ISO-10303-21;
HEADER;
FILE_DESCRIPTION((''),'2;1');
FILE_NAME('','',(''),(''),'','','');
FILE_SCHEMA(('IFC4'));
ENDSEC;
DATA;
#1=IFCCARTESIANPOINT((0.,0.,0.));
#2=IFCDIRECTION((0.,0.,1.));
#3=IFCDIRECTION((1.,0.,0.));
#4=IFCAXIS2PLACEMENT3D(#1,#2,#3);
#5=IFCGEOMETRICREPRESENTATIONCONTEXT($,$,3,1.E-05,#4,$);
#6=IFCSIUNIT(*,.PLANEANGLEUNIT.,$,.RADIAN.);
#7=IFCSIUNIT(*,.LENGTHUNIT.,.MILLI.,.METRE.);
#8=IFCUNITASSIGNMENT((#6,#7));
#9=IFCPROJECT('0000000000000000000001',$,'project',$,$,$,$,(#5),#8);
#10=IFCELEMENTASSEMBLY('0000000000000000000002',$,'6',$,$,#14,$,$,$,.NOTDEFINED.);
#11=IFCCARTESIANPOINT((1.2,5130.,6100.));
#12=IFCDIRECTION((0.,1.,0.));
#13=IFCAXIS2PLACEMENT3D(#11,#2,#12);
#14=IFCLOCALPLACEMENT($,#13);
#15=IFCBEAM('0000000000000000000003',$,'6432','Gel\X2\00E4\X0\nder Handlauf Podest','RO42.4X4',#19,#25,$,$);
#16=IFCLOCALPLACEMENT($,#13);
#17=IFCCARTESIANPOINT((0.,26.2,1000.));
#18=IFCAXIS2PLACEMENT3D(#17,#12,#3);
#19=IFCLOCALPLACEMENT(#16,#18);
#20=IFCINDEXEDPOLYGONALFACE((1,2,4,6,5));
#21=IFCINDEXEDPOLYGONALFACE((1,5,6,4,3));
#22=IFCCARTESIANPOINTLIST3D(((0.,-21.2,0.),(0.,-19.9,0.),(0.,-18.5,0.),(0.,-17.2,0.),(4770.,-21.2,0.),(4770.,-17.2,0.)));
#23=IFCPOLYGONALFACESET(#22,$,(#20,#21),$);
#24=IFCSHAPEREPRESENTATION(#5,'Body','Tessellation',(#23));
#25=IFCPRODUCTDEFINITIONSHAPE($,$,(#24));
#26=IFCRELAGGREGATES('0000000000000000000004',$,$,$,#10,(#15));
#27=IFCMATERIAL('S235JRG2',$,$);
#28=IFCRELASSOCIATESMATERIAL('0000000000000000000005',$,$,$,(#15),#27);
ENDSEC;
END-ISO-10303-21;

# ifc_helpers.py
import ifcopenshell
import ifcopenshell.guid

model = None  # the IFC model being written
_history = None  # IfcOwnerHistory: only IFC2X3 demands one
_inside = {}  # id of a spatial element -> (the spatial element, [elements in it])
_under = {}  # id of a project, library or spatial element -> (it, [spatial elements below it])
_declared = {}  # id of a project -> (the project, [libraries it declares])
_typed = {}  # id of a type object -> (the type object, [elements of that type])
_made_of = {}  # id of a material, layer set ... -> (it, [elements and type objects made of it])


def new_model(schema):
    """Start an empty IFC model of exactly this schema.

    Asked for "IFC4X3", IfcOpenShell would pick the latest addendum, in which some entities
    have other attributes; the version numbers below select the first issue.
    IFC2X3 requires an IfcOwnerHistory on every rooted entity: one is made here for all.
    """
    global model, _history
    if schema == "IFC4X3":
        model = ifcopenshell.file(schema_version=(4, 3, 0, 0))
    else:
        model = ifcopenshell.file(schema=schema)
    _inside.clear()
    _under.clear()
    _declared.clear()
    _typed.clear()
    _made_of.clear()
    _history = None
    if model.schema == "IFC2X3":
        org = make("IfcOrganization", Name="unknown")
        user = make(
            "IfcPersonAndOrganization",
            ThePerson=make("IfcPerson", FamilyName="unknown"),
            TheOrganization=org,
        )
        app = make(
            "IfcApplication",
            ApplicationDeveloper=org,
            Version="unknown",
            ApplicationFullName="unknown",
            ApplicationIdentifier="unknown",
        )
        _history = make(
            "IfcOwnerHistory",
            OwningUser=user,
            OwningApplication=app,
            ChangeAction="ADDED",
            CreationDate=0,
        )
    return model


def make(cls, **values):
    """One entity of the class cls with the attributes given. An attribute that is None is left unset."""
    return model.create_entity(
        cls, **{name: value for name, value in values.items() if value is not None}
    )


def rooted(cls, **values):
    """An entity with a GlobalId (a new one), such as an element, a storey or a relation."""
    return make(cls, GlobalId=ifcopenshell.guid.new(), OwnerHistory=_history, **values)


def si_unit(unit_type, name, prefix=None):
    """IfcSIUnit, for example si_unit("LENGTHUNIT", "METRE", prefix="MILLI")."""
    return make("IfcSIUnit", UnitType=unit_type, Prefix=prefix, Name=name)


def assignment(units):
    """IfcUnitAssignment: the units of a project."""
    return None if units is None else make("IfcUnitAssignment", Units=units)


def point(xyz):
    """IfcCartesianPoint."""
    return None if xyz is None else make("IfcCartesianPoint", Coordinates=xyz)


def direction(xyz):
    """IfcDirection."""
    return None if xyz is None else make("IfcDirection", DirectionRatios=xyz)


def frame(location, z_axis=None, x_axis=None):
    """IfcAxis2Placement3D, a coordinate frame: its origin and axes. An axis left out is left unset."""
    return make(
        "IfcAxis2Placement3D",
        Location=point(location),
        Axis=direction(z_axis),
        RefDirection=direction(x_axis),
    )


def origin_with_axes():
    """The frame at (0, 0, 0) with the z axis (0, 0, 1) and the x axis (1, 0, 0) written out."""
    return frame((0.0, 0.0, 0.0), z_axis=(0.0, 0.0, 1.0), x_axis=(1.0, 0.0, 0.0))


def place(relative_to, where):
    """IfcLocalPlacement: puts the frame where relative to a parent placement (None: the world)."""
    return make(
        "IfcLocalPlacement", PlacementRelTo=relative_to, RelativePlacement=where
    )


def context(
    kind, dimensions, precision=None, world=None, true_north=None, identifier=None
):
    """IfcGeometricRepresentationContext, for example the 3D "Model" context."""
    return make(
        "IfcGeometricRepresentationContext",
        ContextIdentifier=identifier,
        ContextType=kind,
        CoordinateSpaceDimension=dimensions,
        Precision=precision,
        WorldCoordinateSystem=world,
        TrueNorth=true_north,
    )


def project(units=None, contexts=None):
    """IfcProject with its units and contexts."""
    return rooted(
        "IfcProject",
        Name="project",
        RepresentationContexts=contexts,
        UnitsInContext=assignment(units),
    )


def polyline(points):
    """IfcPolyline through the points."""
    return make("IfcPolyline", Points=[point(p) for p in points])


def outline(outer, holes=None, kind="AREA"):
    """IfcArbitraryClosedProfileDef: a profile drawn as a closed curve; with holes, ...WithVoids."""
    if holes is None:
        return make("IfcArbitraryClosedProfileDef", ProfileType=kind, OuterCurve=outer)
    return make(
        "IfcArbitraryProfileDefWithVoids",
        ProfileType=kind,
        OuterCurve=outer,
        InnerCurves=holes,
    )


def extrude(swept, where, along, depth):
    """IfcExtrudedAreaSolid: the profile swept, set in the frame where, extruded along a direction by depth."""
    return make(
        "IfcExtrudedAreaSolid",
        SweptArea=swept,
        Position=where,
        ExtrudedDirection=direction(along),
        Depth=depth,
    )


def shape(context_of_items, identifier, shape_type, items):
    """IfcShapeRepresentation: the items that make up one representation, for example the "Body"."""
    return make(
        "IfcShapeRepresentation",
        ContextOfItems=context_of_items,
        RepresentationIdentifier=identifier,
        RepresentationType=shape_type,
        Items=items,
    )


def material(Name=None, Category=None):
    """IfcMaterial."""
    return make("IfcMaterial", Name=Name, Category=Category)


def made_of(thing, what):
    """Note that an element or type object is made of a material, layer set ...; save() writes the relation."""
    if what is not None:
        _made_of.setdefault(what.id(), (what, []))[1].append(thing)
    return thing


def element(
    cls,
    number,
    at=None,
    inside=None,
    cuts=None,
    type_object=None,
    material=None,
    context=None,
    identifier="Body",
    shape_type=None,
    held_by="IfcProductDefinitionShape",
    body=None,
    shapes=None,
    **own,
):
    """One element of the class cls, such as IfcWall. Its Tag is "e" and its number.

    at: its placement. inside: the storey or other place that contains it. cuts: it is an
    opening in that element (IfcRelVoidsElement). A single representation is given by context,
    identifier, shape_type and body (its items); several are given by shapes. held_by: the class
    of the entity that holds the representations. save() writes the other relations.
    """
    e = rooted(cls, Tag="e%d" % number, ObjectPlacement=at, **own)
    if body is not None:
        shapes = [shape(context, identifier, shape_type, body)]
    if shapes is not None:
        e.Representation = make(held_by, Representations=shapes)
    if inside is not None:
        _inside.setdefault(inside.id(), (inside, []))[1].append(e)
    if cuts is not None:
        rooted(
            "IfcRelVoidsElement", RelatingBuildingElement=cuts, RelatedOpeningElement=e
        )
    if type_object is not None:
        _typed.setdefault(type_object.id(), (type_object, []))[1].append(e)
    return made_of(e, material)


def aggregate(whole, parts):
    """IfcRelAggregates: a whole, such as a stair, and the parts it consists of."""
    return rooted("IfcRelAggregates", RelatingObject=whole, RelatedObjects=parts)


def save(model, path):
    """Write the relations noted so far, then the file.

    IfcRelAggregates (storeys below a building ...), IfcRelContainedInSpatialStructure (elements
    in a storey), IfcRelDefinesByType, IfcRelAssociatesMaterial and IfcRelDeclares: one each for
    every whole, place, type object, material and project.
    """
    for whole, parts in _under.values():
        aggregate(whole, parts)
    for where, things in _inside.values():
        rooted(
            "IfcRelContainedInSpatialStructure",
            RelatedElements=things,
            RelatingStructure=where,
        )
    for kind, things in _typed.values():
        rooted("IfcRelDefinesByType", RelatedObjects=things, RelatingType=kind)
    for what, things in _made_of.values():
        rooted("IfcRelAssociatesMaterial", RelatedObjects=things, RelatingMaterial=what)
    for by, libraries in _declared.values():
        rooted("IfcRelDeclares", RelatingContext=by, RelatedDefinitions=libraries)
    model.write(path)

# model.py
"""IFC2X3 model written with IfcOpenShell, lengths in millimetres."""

from ifc_helpers import new_model, si_unit, frame, origin_with_axes, place, context, project, polyline, outline, extrude, material, element, aggregate, save


model = new_model("IFC2X3")

# Units and contexts
context_of_model = context(None, 3, precision=1e-05, world=origin_with_axes())
ifc_project = project(units=[si_unit("PLANEANGLEUNIT", "RADIAN"), si_unit("LENGTHUNIT", "METRE", prefix="MILLI")], contexts=[context_of_model])

# Element assembly, beam
assembly_placement = place(None, frame((1.2, 5130.0, 6100.0), z_axis=(0.0, 0.0, 1.0), x_axis=(0.0, 1.0, 0.0)))
assembly = element("IfcElementAssembly", 1, at=assembly_placement, Name="6", PredefinedType="NOTDEFINED")
ifc_material = material(Name="S235JRG2")
placement_1 = place(None, frame((1.2, 5130.0, 6100.0), z_axis=(0.0, 0.0, 1.0), x_axis=(0.0, 1.0, 0.0)))
beam_1_placement = place(placement_1, frame((0.0, 26.2, 1000.0), z_axis=(0.0, 1.0, 0.0), x_axis=(1.0, 0.0, 0.0)))
beam_1 = element("IfcBeam", 2, at=beam_1_placement, material=ifc_material, Name="6432", Description="Geländer Handlauf Podest", ObjectType="RO42.4X4", context=context_of_model, shape_type="SweptSolid", body=[
    extrude(outline(polyline([(-21.2, 0.0), (-21.2, 0.0), (-17.2, 0.0), (-17.2, 0.0), (-21.2, 0.0)])), frame((0.0, 0.0, 0.0), z_axis=(1.0, 0.0, 0.0), x_axis=(0.0, 1.0, 0.0)), (0.0, 0.0, 1.0), 4770.0),
])
aggregate(assembly, [beam_1])

save(model, "model.ifc")
